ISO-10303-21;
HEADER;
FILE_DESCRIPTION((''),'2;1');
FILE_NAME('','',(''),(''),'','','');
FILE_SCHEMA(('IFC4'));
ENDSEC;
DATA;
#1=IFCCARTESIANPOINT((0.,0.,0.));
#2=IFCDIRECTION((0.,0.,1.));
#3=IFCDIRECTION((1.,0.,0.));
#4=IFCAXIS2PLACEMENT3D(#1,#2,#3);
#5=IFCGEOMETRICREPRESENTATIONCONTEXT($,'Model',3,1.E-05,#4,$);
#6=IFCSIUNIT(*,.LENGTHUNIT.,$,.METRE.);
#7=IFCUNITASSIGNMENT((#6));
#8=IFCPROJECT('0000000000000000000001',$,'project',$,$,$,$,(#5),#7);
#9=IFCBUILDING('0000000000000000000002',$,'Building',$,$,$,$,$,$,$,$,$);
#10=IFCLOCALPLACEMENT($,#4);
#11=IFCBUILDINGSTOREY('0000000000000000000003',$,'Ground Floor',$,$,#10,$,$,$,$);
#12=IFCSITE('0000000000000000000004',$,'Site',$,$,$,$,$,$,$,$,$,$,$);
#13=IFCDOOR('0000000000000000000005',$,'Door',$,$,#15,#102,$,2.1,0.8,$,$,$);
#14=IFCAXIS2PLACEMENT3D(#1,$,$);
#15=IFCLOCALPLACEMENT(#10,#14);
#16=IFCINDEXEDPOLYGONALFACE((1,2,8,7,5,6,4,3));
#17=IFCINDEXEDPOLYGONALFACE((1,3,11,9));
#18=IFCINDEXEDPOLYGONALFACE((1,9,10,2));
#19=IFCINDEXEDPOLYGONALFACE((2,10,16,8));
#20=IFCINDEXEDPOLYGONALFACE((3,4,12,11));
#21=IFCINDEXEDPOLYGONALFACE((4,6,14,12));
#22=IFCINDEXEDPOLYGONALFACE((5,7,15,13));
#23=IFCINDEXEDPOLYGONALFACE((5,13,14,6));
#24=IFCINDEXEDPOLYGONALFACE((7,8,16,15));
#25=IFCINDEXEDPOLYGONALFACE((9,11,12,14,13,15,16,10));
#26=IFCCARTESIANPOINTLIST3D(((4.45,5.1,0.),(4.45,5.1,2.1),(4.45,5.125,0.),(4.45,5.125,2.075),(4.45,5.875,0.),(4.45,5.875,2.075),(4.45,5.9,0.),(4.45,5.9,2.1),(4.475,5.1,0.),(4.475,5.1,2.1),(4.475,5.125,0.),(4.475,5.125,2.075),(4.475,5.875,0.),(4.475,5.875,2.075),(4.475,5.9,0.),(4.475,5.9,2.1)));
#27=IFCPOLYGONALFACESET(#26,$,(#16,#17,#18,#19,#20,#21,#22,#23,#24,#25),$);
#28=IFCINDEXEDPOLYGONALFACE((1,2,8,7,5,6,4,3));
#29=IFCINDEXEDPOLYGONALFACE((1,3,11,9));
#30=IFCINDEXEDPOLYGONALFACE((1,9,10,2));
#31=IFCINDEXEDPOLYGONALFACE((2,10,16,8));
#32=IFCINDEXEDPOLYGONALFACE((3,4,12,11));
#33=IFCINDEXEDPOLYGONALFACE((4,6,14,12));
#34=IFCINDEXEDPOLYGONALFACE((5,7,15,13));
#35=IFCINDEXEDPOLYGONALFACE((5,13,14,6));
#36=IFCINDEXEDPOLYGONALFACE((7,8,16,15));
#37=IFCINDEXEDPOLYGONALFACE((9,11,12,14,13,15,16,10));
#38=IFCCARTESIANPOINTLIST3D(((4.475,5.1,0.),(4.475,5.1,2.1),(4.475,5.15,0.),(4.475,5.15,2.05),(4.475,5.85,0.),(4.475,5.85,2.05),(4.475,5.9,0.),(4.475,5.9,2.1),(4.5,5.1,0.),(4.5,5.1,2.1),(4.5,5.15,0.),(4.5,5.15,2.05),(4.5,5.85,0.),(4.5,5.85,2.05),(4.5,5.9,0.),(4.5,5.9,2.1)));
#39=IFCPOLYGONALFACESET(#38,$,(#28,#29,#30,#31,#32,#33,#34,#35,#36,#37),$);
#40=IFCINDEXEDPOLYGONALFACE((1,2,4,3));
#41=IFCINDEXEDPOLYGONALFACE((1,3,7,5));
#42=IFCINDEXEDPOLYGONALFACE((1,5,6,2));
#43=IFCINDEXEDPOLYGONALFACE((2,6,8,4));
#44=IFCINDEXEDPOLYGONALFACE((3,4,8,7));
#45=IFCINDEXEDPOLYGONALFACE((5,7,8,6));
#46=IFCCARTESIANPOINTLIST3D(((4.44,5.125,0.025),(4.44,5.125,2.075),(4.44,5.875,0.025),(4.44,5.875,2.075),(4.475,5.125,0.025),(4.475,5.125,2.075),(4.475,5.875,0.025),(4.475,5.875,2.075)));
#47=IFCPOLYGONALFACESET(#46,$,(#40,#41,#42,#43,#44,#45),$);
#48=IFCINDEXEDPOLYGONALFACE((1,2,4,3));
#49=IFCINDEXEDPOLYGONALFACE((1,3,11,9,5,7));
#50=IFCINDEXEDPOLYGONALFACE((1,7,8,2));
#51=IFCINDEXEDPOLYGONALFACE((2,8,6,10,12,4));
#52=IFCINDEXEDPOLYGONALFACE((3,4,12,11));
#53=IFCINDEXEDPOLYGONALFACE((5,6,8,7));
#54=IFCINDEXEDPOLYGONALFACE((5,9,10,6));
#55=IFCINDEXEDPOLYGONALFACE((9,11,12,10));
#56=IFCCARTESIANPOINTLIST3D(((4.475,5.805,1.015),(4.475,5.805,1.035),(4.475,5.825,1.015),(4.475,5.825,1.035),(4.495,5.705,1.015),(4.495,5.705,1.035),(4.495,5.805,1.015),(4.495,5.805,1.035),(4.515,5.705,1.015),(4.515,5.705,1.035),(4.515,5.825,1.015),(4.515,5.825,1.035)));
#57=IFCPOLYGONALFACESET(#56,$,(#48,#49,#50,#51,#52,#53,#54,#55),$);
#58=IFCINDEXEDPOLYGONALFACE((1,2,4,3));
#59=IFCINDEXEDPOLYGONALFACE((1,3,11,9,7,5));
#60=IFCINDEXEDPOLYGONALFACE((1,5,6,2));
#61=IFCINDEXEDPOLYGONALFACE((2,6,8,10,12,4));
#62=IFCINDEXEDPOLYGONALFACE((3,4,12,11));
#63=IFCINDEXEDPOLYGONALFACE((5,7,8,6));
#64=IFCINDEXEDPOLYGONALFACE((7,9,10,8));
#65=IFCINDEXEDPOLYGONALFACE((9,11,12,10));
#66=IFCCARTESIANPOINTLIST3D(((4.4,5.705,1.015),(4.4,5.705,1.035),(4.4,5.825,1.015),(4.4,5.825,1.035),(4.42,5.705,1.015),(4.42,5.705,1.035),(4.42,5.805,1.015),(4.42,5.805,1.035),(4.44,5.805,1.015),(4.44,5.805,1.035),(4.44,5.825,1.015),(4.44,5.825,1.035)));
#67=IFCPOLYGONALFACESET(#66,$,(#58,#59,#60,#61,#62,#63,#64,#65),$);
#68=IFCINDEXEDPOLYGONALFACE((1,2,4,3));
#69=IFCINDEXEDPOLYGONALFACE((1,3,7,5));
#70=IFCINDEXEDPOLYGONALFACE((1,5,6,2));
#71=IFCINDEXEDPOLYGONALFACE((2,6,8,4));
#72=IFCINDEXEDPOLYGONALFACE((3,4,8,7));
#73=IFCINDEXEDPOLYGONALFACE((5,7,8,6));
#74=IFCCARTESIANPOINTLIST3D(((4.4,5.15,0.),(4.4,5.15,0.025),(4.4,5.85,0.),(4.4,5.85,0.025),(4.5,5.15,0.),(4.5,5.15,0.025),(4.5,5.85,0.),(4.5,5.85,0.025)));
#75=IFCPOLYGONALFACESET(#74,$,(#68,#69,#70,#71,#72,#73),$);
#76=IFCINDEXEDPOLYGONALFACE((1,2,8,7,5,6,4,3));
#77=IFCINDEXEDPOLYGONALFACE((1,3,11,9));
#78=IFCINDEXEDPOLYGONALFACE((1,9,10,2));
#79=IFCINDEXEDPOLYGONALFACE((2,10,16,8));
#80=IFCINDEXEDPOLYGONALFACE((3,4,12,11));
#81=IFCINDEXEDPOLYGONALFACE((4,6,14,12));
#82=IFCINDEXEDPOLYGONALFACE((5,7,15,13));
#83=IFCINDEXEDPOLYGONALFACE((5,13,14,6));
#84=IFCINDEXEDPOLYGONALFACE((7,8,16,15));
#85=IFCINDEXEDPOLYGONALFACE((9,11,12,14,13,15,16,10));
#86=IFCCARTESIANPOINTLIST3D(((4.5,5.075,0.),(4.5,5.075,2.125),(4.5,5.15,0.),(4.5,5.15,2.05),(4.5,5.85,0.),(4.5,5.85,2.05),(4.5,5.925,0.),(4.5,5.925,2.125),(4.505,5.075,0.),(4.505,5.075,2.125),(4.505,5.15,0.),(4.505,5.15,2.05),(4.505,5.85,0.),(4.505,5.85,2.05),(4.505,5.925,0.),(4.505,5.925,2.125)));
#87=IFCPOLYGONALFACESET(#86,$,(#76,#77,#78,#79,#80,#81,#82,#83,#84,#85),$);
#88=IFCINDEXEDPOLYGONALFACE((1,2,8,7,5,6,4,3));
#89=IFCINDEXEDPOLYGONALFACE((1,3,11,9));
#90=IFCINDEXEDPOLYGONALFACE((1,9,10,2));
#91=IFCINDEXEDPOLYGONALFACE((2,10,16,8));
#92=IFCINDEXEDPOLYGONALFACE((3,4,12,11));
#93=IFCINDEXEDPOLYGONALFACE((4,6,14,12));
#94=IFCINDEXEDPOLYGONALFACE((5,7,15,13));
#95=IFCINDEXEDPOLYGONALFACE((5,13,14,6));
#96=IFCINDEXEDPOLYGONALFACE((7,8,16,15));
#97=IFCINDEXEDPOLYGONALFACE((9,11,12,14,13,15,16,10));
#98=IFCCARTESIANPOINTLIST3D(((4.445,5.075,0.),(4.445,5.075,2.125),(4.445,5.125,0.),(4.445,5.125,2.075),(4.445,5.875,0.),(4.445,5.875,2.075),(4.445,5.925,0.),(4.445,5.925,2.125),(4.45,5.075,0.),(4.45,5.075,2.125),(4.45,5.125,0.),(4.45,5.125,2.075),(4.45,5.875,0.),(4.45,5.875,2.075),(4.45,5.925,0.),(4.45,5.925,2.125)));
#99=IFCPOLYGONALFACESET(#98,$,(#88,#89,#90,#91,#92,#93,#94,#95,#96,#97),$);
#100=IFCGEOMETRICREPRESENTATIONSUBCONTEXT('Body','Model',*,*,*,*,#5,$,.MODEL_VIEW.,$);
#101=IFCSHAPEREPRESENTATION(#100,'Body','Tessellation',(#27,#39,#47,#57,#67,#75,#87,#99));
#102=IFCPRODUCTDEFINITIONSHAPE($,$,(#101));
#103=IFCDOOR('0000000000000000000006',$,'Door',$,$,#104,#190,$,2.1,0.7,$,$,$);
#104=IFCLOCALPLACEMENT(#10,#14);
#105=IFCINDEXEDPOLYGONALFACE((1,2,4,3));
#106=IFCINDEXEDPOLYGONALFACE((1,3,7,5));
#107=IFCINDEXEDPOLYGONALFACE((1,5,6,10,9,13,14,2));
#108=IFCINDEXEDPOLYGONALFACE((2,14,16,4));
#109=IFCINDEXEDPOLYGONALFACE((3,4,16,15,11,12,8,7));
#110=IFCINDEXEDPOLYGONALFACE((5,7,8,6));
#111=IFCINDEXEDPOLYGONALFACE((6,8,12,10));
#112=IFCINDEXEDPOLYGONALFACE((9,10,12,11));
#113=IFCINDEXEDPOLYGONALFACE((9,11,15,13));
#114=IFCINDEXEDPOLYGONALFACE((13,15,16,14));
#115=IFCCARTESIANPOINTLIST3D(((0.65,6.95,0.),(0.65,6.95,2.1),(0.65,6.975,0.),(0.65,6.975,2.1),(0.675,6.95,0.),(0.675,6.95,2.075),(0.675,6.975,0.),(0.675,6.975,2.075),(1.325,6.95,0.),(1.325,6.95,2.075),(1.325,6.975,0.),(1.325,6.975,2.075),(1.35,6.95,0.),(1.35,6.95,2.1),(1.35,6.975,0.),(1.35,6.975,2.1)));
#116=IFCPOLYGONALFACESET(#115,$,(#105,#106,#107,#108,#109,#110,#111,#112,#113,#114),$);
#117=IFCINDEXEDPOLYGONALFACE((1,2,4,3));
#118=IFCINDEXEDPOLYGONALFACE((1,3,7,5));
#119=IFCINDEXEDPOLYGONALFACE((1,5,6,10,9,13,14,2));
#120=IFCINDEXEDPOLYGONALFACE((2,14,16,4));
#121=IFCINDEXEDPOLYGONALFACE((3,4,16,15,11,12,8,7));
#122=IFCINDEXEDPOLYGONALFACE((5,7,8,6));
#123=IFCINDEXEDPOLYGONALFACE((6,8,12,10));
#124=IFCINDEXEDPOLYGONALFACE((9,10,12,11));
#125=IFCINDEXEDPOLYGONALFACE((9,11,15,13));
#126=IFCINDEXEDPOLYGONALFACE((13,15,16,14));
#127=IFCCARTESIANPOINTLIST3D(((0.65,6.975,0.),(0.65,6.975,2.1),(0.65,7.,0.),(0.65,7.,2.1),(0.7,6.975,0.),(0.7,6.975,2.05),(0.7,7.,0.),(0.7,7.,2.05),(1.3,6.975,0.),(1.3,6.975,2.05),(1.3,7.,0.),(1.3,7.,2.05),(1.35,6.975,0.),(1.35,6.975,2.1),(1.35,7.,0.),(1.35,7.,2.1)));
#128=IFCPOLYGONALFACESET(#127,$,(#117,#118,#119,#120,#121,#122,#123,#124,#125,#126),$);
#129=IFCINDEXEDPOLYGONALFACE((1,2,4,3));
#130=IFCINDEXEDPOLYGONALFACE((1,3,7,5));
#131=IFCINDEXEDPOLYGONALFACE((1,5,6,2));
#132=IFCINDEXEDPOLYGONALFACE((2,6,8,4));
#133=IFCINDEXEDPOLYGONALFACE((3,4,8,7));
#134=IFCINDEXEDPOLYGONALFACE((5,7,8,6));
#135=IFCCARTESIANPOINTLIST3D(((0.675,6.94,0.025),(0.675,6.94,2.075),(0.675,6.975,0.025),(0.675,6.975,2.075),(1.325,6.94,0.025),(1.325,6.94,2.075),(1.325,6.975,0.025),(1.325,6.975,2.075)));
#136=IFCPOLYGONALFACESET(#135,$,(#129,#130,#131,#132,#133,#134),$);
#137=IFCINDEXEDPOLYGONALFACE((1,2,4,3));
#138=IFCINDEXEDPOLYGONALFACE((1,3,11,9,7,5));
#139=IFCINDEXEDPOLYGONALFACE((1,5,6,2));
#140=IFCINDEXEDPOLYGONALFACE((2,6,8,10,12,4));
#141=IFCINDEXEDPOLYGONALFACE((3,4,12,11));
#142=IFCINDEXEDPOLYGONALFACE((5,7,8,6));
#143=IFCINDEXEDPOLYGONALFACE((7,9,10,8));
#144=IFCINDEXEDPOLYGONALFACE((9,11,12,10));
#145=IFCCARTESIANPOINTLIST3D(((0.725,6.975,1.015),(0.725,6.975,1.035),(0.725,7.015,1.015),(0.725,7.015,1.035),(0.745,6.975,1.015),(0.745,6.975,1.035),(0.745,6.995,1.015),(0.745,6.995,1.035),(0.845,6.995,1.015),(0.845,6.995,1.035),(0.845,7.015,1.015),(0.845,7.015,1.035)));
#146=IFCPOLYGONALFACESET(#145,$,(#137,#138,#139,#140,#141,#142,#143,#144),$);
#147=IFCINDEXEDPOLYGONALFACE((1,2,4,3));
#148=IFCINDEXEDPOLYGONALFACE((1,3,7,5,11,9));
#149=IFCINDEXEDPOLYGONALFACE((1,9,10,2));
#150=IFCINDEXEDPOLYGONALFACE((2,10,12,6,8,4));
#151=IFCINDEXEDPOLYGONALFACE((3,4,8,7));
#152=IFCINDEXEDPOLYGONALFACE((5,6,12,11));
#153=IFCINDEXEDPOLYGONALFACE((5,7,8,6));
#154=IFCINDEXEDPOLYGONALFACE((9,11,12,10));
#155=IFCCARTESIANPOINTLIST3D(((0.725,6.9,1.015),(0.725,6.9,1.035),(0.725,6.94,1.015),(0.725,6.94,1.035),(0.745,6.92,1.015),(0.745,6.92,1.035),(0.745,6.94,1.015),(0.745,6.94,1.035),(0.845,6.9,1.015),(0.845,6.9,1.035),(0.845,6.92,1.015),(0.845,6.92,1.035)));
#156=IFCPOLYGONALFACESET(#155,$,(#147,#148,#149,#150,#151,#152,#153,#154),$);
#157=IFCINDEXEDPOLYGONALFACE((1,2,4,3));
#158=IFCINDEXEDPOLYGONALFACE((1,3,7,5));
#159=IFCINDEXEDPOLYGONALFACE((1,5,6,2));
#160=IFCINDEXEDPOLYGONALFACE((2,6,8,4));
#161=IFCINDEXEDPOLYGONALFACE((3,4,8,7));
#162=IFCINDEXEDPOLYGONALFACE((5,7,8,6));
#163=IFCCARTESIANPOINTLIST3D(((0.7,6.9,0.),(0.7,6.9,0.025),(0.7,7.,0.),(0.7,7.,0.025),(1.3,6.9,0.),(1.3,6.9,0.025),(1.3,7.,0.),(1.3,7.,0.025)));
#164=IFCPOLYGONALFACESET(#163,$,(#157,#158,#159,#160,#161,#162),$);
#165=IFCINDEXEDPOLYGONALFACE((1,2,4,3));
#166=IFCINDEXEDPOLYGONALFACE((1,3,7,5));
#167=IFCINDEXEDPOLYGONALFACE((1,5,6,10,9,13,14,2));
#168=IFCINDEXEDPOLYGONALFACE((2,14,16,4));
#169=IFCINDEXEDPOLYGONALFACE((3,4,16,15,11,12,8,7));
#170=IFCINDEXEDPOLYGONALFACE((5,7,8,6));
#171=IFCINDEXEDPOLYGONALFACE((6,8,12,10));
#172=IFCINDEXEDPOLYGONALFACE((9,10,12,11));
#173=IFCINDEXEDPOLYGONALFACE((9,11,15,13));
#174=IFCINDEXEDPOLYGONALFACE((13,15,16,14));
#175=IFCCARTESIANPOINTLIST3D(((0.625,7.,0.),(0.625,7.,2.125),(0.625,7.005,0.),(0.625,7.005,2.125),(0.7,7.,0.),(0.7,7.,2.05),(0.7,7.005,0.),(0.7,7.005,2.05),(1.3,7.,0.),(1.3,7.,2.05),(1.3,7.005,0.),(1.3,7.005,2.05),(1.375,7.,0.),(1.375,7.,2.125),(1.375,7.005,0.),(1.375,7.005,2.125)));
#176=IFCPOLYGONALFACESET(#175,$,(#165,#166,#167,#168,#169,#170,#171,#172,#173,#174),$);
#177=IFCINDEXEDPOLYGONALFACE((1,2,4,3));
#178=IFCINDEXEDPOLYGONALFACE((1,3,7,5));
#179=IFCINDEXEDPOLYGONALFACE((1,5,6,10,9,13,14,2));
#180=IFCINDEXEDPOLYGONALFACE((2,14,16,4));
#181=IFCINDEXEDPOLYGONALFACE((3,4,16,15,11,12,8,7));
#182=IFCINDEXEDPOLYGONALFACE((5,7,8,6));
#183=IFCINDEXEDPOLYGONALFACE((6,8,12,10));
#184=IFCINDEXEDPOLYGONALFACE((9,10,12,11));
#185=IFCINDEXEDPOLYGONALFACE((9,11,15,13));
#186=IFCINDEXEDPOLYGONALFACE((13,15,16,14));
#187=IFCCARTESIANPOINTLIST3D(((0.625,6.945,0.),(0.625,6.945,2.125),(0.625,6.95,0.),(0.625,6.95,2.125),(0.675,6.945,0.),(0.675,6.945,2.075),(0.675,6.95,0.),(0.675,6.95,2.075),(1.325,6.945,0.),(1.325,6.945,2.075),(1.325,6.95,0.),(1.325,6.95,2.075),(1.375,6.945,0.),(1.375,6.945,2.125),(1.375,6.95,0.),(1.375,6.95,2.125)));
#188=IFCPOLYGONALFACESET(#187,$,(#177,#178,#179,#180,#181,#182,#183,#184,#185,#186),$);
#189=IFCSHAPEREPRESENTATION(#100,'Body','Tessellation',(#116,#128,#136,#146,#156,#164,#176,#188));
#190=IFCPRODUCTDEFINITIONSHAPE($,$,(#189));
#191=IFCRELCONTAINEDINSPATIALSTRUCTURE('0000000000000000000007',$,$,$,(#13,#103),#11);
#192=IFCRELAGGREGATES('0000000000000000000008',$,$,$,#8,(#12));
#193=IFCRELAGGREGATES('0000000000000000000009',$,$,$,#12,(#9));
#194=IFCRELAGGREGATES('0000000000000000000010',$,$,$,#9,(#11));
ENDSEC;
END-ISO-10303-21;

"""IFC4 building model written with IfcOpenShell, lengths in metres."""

from ifc_helpers import new_model, si_unit, frame, origin_with_axes, place, context, subcontext, project, spatial, line, indexed_curve, outline, extrude, element, save


model = new_model("IFC4")

# Units and contexts
model_context = context("Model", 3, precision=1e-05, world=origin_with_axes())
body_context = subcontext(model_context, "Body", "Model", "MODEL_VIEW")
ifc_project = project(units=[si_unit("LENGTHUNIT", "METRE")], contexts=[model_context])

# Site, building, storey
site = spatial("IfcSite", under=ifc_project, Name="Site")
building = spatial("IfcBuilding", under=site, Name="Building")
storey_placement = place(None, origin_with_axes())
storey = spatial("IfcBuildingStorey", under=building, at=storey_placement, Name="Ground Floor")

# Doors
door_1_placement = place(storey_placement, frame((4.5, 5.1, 0.0), z_axis=(0.0, 0.0, 1.0), x_axis=(0.0, 1.0, 0.0)))
element("IfcDoor", 1, at=door_1_placement, inside=storey, Name="Door", OverallHeight=2.1, OverallWidth=0.8, context=body_context, shape_type="SweptSolid", body=[
    extrude(outline(indexed_curve([(0.0, 0.0), (0.0, 2.1), (0.8, 2.1), (0.8, 0.0), (0.775, 0.0), (0.775, 2.075), (0.025, 2.075), (0.025, 0.0)], segments=[line(1, 2, 3, 4, 5, 6, 7, 8, 1)])), frame((0.0, 0.025, 0.0), z_axis=(0.0, -1.0, 0.0), x_axis=(1.0, 0.0, 0.0)), (0.0, 0.0, -1.0), 0.025),
    extrude(outline(indexed_curve([(0.0, 0.0), (0.0, 2.1), (0.8, 2.1), (0.8, 0.0), (0.75, 0.0), (0.75, 2.05), (0.05, 2.05), (0.05, 0.0)], segments=[line(1, 2, 3, 4, 5, 6, 7, 8, 1)])), frame((0.0, 0.0, 0.0), z_axis=(0.0, -1.0, 0.0), x_axis=(1.0, 0.0, 0.0)), (0.0, 0.0, -1.0), 0.025),
    extrude(outline(indexed_curve([(0.0, 0.0), (0.75, 0.0), (0.75, 0.035), (0.0, 0.035)], segments=[line(1, 2, 3, 4, 1)])), frame((0.025, 0.025, 0.025), z_axis=(0.0, 0.0, 1.0), x_axis=(1.0, 0.0, 0.0)), (0.0, 0.0, 1.0), 2.05),
    extrude(outline(indexed_curve([(0.0, 0.0), (0.0, -0.04), (-0.12, -0.04), (-0.12, -0.02), (-0.02, -0.02), (-0.02, 0.0)], segments=[line(1, 2, 3, 4, 5, 6, 1)])), frame((0.725, 0.025, 1.015), z_axis=(0.0, 0.0, 1.0), x_axis=(1.0, 0.0, 0.0)), (0.0, 0.0, 1.0), 0.02),
    extrude(outline(indexed_curve([(0.0, 0.0), (0.0, 0.04), (-0.12, 0.04), (-0.12, 0.02), (-0.02, 0.02), (-0.02, 0.0)], segments=[line(1, 2, 3, 4, 5, 6, 1)])), frame((0.725, 0.06, 1.015), z_axis=(0.0, 0.0, 1.0), x_axis=(1.0, 0.0, 0.0)), (0.0, 0.0, 1.0), 0.02),
    extrude(outline(indexed_curve([(0.0, 0.0), (0.7, 0.0), (0.7, 0.1), (0.0, 0.1)], segments=[line(1, 2, 3, 4, 1)])), frame((0.05, 0.0, 0.0), z_axis=(0.0, 0.0, 1.0), x_axis=(1.0, 0.0, 0.0)), (0.0, 0.0, 1.0), 0.025),
    extrude(outline(indexed_curve([(0.0, 0.0), (0.0, 2.125), (0.85, 2.125), (0.85, 0.0), (0.775, 0.0), (0.775, 2.05), (0.075, 2.05), (0.075, 0.0)], segments=[line(1, 2, 3, 4, 5, 6, 7, 8, 1)])), frame((-0.025, -0.005, 0.0), z_axis=(0.0, -1.0, 0.0), x_axis=(1.0, 0.0, 0.0)), (0.0, 0.0, -1.0), 0.005),
    extrude(outline(indexed_curve([(0.0, 0.0), (0.0, 2.125), (0.85, 2.125), (0.85, 0.0), (0.8, 0.0), (0.8, 2.075), (0.05, 2.075), (0.05, 0.0)], segments=[line(1, 2, 3, 4, 5, 6, 7, 8, 1)])), frame((-0.025, 0.05, 0.0), z_axis=(0.0, -1.0, 0.0), x_axis=(1.0, 0.0, 0.0)), (0.0, 0.0, -1.0), 0.005),
])
door_2_placement = place(storey_placement, frame((1.35, 7.0, 0.0), z_axis=(0.0, 0.0, 1.0), x_axis=(-1.0, 0.0, 0.0)))
element("IfcDoor", 2, at=door_2_placement, inside=storey, Name="Door", OverallHeight=2.1, OverallWidth=0.7, context=body_context, shape_type="SweptSolid", body=[
    extrude(outline(indexed_curve([(0.0, 0.0), (0.0, 2.1), (0.7, 2.1), (0.7, 0.0), (0.675, 0.0), (0.675, 2.075), (0.025, 2.075), (0.025, 0.0)], segments=[line(1, 2, 3, 4, 5, 6, 7, 8, 1)])), frame((0.0, 0.025, 0.0), z_axis=(0.0, -1.0, 0.0), x_axis=(1.0, 0.0, 0.0)), (0.0, 0.0, -1.0), 0.025),
    extrude(outline(indexed_curve([(0.0, 0.0), (0.0, 2.1), (0.7, 2.1), (0.7, 0.0), (0.65, 0.0), (0.65, 2.05), (0.05, 2.05), (0.05, 0.0)], segments=[line(1, 2, 3, 4, 5, 6, 7, 8, 1)])), frame((0.0, 0.0, 0.0), z_axis=(0.0, -1.0, 0.0), x_axis=(1.0, 0.0, 0.0)), (0.0, 0.0, -1.0), 0.025),
    extrude(outline(indexed_curve([(0.0, 0.0), (0.65, 0.0), (0.65, 0.035), (0.0, 0.035)], segments=[line(1, 2, 3, 4, 1)])), frame((0.025, 0.025, 0.025), z_axis=(0.0, 0.0, 1.0), x_axis=(1.0, 0.0, 0.0)), (0.0, 0.0, 1.0), 2.05),
    extrude(outline(indexed_curve([(0.0, 0.0), (0.0, -0.04), (-0.12, -0.04), (-0.12, -0.02), (-0.02, -0.02), (-0.02, 0.0)], segments=[line(1, 2, 3, 4, 5, 6, 1)])), frame((0.625, 0.025, 1.015), z_axis=(0.0, 0.0, 1.0), x_axis=(1.0, 0.0, 0.0)), (0.0, 0.0, 1.0), 0.02),
    extrude(outline(indexed_curve([(0.0, 0.0), (0.0, 0.04), (-0.12, 0.04), (-0.12, 0.02), (-0.02, 0.02), (-0.02, 0.0)], segments=[line(1, 2, 3, 4, 5, 6, 1)])), frame((0.625, 0.06, 1.015), z_axis=(0.0, 0.0, 1.0), x_axis=(1.0, 0.0, 0.0)), (0.0, 0.0, 1.0), 0.02),
    extrude(outline(indexed_curve([(0.0, 0.0), (0.6, 0.0), (0.6, 0.1), (0.0, 0.1)], segments=[line(1, 2, 3, 4, 1)])), frame((0.05, 0.0, 0.0), z_axis=(0.0, 0.0, 1.0), x_axis=(1.0, 0.0, 0.0)), (0.0, 0.0, 1.0), 0.025),
    extrude(outline(indexed_curve([(0.0, 0.0), (0.0, 2.125), (0.75, 2.125), (0.75, 0.0), (0.675, 0.0), (0.675, 2.05), (0.075, 2.05), (0.075, 0.0)], segments=[line(1, 2, 3, 4, 5, 6, 7, 8, 1)])), frame((-0.025, -0.005, 0.0), z_axis=(0.0, -1.0, 0.0), x_axis=(1.0, 0.0, 0.0)), (0.0, 0.0, -1.0), 0.005),
    extrude(outline(indexed_curve([(0.0, 0.0), (0.0, 2.125), (0.75, 2.125), (0.75, 0.0), (0.7, 0.0), (0.7, 2.075), (0.05, 2.075), (0.05, 0.0)], segments=[line(1, 2, 3, 4, 5, 6, 7, 8, 1)])), frame((-0.025, 0.05, 0.0), z_axis=(0.0, -1.0, 0.0), x_axis=(1.0, 0.0, 0.0)), (0.0, 0.0, -1.0), 0.005),
])

save(model, "model.ifc")
